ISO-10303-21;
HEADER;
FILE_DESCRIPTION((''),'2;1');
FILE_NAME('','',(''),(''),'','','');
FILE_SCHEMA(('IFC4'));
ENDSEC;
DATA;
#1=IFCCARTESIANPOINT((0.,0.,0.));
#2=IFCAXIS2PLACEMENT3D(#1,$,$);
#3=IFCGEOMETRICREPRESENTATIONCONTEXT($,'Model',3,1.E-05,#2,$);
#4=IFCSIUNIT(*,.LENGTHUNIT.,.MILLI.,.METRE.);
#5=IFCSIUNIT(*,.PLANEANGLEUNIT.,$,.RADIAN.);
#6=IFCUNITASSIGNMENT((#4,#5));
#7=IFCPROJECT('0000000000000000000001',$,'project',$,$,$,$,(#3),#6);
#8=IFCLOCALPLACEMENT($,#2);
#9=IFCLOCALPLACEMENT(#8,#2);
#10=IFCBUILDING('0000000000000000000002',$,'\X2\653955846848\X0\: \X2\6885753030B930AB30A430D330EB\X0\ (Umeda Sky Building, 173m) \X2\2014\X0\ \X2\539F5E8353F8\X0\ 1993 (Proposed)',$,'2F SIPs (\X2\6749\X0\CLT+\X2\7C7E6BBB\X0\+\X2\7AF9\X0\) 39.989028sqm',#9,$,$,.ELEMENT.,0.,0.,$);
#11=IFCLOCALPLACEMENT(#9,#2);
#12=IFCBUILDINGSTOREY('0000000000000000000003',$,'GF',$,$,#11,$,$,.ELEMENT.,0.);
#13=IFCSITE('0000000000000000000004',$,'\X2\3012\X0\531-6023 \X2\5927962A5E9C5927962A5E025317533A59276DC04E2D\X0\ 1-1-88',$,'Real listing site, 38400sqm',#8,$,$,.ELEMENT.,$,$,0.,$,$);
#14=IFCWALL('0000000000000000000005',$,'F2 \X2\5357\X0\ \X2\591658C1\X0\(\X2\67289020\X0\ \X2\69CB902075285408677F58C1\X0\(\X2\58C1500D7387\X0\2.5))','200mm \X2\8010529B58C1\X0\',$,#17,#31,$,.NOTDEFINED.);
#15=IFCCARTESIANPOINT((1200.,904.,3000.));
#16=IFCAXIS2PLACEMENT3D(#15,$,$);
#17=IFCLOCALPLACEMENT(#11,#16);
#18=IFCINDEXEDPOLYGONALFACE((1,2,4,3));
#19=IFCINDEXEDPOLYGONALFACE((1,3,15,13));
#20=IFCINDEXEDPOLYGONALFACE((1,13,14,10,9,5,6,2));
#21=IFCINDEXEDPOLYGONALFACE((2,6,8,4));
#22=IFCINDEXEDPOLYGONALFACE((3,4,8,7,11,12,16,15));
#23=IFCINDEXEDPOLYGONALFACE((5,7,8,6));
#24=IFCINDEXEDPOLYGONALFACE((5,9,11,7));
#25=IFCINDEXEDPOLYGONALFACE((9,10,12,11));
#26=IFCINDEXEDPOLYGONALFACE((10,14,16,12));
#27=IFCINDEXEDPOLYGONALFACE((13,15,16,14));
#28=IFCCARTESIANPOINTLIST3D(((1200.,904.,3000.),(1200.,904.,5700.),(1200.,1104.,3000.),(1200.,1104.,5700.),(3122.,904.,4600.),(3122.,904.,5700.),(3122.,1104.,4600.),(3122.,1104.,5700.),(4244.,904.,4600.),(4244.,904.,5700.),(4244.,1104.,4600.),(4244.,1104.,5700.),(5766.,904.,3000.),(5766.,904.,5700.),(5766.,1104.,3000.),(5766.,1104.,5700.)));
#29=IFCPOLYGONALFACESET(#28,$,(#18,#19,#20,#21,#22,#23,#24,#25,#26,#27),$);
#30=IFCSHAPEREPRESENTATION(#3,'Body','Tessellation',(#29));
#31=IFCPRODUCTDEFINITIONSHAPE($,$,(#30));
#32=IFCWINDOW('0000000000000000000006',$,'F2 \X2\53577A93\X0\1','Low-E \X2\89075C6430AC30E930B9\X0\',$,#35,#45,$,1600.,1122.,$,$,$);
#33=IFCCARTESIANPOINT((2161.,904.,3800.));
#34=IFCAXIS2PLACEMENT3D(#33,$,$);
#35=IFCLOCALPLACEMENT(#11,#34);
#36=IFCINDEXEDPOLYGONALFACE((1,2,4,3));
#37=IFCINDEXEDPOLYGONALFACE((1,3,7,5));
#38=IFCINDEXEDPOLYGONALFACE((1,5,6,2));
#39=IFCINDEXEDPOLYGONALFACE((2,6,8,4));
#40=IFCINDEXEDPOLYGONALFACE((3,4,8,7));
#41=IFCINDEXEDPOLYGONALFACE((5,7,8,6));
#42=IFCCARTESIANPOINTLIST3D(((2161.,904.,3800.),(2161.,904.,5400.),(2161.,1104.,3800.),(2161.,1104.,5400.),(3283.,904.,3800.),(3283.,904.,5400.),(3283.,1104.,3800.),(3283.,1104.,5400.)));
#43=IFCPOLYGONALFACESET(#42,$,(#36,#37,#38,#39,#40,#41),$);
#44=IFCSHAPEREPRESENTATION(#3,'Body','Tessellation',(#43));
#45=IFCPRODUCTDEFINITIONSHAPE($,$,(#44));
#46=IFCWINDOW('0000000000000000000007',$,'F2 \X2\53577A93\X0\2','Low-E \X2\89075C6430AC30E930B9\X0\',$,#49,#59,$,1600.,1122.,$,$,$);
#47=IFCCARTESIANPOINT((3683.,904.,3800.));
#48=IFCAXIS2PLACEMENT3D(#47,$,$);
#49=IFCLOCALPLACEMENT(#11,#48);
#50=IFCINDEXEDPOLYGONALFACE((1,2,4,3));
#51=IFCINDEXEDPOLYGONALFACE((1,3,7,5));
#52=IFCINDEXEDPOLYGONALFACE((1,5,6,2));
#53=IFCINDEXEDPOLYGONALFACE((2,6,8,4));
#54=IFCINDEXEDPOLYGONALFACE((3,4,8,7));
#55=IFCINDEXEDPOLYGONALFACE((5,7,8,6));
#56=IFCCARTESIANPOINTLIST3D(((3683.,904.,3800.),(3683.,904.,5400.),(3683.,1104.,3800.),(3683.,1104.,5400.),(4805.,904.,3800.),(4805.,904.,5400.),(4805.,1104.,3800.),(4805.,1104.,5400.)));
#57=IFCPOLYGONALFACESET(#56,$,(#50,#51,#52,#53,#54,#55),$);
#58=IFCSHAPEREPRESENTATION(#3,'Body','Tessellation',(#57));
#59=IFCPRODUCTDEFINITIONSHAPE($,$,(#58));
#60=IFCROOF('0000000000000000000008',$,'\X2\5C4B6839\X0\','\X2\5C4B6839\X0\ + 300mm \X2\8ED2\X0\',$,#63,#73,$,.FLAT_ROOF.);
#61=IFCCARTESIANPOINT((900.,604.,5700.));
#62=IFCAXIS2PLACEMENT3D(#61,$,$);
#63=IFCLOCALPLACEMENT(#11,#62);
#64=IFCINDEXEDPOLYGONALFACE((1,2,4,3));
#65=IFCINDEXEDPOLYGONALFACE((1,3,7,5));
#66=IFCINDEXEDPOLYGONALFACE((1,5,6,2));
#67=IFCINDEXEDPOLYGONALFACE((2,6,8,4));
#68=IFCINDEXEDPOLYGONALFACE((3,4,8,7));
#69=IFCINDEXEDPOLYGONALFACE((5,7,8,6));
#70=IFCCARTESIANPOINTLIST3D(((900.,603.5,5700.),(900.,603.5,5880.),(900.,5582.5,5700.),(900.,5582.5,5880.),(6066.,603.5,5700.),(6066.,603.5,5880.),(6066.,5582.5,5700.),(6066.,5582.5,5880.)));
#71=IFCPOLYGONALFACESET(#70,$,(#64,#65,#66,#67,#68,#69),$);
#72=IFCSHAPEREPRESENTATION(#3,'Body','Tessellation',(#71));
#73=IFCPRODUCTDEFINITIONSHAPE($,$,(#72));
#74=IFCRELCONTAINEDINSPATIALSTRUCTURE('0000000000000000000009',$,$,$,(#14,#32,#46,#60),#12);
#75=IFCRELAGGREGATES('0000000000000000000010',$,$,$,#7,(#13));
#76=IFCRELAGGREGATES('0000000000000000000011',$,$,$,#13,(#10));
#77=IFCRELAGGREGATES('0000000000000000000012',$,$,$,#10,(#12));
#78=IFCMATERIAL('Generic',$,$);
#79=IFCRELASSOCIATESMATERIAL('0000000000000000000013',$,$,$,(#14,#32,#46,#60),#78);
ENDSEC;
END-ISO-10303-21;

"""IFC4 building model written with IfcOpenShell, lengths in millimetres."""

from ifc_helpers import new_model, si_unit, frame, frame_2d, origin, place, context, project, spatial, rectangle, extrude, material, element, fill, save


model = new_model("IFC4")

# Units and contexts
model_context = context("Model", 3, precision=1e-05, world=origin())
ifc_project = project(units=[si_unit("LENGTHUNIT", "METRE", prefix="MILLI"), si_unit("PLANEANGLEUNIT", "RADIAN")], contexts=[model_context])

# Site, building, storey
site_placement = place(None, origin())
site = spatial("IfcSite", under=ifc_project, at=site_placement, Name="〒531-6023 大阪府大阪市北区大淀中 1-1-88", ObjectType="Real listing site, 38400sqm", CompositionType="ELEMENT", RefElevation=0.0)
building_placement = place(site_placement, origin())
building = spatial("IfcBuilding", under=site, at=building_placement, Name="改善案: 梅田スカイビル (Umeda Sky Building, 173m) — 原広司 1993 (Proposed)", ObjectType="2F SIPs (杉CLT+籾殻+竹) 39.989028sqm", CompositionType="ELEMENT", ElevationOfRefHeight=0.0, ElevationOfTerrain=0.0)
storey_placement = place(building_placement, origin())
storey = spatial("IfcBuildingStorey", under=building, at=storey_placement, Name="GF", CompositionType="ELEMENT", Elevation=0.0)

# Shared definitions
ifc_material_1 = material(Name="Generic")

# Wall, openings, windows
wall_1_placement = place(storey_placement, frame((1200.0, 904.0, 3000.0)))
wall_1 = element("IfcWall", 1, at=wall_1_placement, inside=storey, material=ifc_material_1, Name="F2 南 外壁(木造 構造用合板壁(壁倍率2.5))", Description="200mm 耐力壁", PredefinedType="NOTDEFINED", context=model_context, shape_type="SweptSolid", body=[
    extrude(rectangle(XDim=4566.0, YDim=200.0, at=frame_2d((2283.0, 100.0))), frame((1200.0, 904.0, 3000.0)), (0.0, 0.0, 1.0), 2700.0),
])
opening_1_placement = place(storey_placement, frame((2161.0, 904.0, 3800.0)))
opening_1 = element("IfcOpeningElement", 2, at=opening_1_placement, cuts=wall_1, PredefinedType="NOTDEFINED", context=model_context, shape_type="SweptSolid", body=[
    extrude(rectangle(XDim=1122.0, YDim=200.0, at=frame_2d((561.0, 100.0))), frame((2161.0, 904.0, 3800.0)), (0.0, 0.0, 1.0), 1600.0),
])
opening_2_placement = place(storey_placement, frame((3683.0, 904.0, 3800.0)))
opening_2 = element("IfcOpeningElement", 3, at=opening_2_placement, cuts=wall_1, PredefinedType="NOTDEFINED", context=model_context, shape_type="SweptSolid", body=[
    extrude(rectangle(XDim=1122.0, YDim=200.0, at=frame_2d((561.0, 100.0))), frame((3683.0, 904.0, 3800.0)), (0.0, 0.0, 1.0), 1600.0),
])
window_1_placement = place(storey_placement, frame((2161.0, 904.0, 3800.0)))
window_1 = element("IfcWindow", 4, at=window_1_placement, inside=storey, material=ifc_material_1, Name="F2 南窓1", Description="Low-E 複層ガラス", OverallHeight=1600.0, OverallWidth=1122.0, context=model_context, shape_type="SweptSolid", body=[
    extrude(rectangle(XDim=1122.0, YDim=200.0, at=frame_2d((561.0, 100.0))), frame((2161.0, 904.0, 3800.0)), (0.0, 0.0, 1.0), 1600.0),
])
fill(opening_1, window_1)
window_2_placement = place(storey_placement, frame((3683.0, 904.0, 3800.0)))
window_2 = element("IfcWindow", 5, at=window_2_placement, inside=storey, material=ifc_material_1, Name="F2 南窓2", Description="Low-E 複層ガラス", OverallHeight=1600.0, OverallWidth=1122.0, context=model_context, shape_type="SweptSolid", body=[
    extrude(rectangle(XDim=1122.0, YDim=200.0, at=frame_2d((561.0, 100.0))), frame((3683.0, 904.0, 3800.0)), (0.0, 0.0, 1.0), 1600.0),
])
fill(opening_2, window_2)

# Roof
roof_placement = place(storey_placement, frame((900.0, 604.0, 5700.0)))
element("IfcRoof", 6, at=roof_placement, inside=storey, material=ifc_material_1, Name="屋根", Description="屋根 + 300mm 軒", PredefinedType="FLAT_ROOF", context=model_context, shape_type="SweptSolid", body=[
    extrude(rectangle(XDim=5166.0, YDim=4979.0, at=frame_2d((2583.0, 2489.0))), frame((900.0, 604.0, 5700.0)), (0.0, 0.0, 1.0), 180.0),
])

save(model, "model.ifc")
